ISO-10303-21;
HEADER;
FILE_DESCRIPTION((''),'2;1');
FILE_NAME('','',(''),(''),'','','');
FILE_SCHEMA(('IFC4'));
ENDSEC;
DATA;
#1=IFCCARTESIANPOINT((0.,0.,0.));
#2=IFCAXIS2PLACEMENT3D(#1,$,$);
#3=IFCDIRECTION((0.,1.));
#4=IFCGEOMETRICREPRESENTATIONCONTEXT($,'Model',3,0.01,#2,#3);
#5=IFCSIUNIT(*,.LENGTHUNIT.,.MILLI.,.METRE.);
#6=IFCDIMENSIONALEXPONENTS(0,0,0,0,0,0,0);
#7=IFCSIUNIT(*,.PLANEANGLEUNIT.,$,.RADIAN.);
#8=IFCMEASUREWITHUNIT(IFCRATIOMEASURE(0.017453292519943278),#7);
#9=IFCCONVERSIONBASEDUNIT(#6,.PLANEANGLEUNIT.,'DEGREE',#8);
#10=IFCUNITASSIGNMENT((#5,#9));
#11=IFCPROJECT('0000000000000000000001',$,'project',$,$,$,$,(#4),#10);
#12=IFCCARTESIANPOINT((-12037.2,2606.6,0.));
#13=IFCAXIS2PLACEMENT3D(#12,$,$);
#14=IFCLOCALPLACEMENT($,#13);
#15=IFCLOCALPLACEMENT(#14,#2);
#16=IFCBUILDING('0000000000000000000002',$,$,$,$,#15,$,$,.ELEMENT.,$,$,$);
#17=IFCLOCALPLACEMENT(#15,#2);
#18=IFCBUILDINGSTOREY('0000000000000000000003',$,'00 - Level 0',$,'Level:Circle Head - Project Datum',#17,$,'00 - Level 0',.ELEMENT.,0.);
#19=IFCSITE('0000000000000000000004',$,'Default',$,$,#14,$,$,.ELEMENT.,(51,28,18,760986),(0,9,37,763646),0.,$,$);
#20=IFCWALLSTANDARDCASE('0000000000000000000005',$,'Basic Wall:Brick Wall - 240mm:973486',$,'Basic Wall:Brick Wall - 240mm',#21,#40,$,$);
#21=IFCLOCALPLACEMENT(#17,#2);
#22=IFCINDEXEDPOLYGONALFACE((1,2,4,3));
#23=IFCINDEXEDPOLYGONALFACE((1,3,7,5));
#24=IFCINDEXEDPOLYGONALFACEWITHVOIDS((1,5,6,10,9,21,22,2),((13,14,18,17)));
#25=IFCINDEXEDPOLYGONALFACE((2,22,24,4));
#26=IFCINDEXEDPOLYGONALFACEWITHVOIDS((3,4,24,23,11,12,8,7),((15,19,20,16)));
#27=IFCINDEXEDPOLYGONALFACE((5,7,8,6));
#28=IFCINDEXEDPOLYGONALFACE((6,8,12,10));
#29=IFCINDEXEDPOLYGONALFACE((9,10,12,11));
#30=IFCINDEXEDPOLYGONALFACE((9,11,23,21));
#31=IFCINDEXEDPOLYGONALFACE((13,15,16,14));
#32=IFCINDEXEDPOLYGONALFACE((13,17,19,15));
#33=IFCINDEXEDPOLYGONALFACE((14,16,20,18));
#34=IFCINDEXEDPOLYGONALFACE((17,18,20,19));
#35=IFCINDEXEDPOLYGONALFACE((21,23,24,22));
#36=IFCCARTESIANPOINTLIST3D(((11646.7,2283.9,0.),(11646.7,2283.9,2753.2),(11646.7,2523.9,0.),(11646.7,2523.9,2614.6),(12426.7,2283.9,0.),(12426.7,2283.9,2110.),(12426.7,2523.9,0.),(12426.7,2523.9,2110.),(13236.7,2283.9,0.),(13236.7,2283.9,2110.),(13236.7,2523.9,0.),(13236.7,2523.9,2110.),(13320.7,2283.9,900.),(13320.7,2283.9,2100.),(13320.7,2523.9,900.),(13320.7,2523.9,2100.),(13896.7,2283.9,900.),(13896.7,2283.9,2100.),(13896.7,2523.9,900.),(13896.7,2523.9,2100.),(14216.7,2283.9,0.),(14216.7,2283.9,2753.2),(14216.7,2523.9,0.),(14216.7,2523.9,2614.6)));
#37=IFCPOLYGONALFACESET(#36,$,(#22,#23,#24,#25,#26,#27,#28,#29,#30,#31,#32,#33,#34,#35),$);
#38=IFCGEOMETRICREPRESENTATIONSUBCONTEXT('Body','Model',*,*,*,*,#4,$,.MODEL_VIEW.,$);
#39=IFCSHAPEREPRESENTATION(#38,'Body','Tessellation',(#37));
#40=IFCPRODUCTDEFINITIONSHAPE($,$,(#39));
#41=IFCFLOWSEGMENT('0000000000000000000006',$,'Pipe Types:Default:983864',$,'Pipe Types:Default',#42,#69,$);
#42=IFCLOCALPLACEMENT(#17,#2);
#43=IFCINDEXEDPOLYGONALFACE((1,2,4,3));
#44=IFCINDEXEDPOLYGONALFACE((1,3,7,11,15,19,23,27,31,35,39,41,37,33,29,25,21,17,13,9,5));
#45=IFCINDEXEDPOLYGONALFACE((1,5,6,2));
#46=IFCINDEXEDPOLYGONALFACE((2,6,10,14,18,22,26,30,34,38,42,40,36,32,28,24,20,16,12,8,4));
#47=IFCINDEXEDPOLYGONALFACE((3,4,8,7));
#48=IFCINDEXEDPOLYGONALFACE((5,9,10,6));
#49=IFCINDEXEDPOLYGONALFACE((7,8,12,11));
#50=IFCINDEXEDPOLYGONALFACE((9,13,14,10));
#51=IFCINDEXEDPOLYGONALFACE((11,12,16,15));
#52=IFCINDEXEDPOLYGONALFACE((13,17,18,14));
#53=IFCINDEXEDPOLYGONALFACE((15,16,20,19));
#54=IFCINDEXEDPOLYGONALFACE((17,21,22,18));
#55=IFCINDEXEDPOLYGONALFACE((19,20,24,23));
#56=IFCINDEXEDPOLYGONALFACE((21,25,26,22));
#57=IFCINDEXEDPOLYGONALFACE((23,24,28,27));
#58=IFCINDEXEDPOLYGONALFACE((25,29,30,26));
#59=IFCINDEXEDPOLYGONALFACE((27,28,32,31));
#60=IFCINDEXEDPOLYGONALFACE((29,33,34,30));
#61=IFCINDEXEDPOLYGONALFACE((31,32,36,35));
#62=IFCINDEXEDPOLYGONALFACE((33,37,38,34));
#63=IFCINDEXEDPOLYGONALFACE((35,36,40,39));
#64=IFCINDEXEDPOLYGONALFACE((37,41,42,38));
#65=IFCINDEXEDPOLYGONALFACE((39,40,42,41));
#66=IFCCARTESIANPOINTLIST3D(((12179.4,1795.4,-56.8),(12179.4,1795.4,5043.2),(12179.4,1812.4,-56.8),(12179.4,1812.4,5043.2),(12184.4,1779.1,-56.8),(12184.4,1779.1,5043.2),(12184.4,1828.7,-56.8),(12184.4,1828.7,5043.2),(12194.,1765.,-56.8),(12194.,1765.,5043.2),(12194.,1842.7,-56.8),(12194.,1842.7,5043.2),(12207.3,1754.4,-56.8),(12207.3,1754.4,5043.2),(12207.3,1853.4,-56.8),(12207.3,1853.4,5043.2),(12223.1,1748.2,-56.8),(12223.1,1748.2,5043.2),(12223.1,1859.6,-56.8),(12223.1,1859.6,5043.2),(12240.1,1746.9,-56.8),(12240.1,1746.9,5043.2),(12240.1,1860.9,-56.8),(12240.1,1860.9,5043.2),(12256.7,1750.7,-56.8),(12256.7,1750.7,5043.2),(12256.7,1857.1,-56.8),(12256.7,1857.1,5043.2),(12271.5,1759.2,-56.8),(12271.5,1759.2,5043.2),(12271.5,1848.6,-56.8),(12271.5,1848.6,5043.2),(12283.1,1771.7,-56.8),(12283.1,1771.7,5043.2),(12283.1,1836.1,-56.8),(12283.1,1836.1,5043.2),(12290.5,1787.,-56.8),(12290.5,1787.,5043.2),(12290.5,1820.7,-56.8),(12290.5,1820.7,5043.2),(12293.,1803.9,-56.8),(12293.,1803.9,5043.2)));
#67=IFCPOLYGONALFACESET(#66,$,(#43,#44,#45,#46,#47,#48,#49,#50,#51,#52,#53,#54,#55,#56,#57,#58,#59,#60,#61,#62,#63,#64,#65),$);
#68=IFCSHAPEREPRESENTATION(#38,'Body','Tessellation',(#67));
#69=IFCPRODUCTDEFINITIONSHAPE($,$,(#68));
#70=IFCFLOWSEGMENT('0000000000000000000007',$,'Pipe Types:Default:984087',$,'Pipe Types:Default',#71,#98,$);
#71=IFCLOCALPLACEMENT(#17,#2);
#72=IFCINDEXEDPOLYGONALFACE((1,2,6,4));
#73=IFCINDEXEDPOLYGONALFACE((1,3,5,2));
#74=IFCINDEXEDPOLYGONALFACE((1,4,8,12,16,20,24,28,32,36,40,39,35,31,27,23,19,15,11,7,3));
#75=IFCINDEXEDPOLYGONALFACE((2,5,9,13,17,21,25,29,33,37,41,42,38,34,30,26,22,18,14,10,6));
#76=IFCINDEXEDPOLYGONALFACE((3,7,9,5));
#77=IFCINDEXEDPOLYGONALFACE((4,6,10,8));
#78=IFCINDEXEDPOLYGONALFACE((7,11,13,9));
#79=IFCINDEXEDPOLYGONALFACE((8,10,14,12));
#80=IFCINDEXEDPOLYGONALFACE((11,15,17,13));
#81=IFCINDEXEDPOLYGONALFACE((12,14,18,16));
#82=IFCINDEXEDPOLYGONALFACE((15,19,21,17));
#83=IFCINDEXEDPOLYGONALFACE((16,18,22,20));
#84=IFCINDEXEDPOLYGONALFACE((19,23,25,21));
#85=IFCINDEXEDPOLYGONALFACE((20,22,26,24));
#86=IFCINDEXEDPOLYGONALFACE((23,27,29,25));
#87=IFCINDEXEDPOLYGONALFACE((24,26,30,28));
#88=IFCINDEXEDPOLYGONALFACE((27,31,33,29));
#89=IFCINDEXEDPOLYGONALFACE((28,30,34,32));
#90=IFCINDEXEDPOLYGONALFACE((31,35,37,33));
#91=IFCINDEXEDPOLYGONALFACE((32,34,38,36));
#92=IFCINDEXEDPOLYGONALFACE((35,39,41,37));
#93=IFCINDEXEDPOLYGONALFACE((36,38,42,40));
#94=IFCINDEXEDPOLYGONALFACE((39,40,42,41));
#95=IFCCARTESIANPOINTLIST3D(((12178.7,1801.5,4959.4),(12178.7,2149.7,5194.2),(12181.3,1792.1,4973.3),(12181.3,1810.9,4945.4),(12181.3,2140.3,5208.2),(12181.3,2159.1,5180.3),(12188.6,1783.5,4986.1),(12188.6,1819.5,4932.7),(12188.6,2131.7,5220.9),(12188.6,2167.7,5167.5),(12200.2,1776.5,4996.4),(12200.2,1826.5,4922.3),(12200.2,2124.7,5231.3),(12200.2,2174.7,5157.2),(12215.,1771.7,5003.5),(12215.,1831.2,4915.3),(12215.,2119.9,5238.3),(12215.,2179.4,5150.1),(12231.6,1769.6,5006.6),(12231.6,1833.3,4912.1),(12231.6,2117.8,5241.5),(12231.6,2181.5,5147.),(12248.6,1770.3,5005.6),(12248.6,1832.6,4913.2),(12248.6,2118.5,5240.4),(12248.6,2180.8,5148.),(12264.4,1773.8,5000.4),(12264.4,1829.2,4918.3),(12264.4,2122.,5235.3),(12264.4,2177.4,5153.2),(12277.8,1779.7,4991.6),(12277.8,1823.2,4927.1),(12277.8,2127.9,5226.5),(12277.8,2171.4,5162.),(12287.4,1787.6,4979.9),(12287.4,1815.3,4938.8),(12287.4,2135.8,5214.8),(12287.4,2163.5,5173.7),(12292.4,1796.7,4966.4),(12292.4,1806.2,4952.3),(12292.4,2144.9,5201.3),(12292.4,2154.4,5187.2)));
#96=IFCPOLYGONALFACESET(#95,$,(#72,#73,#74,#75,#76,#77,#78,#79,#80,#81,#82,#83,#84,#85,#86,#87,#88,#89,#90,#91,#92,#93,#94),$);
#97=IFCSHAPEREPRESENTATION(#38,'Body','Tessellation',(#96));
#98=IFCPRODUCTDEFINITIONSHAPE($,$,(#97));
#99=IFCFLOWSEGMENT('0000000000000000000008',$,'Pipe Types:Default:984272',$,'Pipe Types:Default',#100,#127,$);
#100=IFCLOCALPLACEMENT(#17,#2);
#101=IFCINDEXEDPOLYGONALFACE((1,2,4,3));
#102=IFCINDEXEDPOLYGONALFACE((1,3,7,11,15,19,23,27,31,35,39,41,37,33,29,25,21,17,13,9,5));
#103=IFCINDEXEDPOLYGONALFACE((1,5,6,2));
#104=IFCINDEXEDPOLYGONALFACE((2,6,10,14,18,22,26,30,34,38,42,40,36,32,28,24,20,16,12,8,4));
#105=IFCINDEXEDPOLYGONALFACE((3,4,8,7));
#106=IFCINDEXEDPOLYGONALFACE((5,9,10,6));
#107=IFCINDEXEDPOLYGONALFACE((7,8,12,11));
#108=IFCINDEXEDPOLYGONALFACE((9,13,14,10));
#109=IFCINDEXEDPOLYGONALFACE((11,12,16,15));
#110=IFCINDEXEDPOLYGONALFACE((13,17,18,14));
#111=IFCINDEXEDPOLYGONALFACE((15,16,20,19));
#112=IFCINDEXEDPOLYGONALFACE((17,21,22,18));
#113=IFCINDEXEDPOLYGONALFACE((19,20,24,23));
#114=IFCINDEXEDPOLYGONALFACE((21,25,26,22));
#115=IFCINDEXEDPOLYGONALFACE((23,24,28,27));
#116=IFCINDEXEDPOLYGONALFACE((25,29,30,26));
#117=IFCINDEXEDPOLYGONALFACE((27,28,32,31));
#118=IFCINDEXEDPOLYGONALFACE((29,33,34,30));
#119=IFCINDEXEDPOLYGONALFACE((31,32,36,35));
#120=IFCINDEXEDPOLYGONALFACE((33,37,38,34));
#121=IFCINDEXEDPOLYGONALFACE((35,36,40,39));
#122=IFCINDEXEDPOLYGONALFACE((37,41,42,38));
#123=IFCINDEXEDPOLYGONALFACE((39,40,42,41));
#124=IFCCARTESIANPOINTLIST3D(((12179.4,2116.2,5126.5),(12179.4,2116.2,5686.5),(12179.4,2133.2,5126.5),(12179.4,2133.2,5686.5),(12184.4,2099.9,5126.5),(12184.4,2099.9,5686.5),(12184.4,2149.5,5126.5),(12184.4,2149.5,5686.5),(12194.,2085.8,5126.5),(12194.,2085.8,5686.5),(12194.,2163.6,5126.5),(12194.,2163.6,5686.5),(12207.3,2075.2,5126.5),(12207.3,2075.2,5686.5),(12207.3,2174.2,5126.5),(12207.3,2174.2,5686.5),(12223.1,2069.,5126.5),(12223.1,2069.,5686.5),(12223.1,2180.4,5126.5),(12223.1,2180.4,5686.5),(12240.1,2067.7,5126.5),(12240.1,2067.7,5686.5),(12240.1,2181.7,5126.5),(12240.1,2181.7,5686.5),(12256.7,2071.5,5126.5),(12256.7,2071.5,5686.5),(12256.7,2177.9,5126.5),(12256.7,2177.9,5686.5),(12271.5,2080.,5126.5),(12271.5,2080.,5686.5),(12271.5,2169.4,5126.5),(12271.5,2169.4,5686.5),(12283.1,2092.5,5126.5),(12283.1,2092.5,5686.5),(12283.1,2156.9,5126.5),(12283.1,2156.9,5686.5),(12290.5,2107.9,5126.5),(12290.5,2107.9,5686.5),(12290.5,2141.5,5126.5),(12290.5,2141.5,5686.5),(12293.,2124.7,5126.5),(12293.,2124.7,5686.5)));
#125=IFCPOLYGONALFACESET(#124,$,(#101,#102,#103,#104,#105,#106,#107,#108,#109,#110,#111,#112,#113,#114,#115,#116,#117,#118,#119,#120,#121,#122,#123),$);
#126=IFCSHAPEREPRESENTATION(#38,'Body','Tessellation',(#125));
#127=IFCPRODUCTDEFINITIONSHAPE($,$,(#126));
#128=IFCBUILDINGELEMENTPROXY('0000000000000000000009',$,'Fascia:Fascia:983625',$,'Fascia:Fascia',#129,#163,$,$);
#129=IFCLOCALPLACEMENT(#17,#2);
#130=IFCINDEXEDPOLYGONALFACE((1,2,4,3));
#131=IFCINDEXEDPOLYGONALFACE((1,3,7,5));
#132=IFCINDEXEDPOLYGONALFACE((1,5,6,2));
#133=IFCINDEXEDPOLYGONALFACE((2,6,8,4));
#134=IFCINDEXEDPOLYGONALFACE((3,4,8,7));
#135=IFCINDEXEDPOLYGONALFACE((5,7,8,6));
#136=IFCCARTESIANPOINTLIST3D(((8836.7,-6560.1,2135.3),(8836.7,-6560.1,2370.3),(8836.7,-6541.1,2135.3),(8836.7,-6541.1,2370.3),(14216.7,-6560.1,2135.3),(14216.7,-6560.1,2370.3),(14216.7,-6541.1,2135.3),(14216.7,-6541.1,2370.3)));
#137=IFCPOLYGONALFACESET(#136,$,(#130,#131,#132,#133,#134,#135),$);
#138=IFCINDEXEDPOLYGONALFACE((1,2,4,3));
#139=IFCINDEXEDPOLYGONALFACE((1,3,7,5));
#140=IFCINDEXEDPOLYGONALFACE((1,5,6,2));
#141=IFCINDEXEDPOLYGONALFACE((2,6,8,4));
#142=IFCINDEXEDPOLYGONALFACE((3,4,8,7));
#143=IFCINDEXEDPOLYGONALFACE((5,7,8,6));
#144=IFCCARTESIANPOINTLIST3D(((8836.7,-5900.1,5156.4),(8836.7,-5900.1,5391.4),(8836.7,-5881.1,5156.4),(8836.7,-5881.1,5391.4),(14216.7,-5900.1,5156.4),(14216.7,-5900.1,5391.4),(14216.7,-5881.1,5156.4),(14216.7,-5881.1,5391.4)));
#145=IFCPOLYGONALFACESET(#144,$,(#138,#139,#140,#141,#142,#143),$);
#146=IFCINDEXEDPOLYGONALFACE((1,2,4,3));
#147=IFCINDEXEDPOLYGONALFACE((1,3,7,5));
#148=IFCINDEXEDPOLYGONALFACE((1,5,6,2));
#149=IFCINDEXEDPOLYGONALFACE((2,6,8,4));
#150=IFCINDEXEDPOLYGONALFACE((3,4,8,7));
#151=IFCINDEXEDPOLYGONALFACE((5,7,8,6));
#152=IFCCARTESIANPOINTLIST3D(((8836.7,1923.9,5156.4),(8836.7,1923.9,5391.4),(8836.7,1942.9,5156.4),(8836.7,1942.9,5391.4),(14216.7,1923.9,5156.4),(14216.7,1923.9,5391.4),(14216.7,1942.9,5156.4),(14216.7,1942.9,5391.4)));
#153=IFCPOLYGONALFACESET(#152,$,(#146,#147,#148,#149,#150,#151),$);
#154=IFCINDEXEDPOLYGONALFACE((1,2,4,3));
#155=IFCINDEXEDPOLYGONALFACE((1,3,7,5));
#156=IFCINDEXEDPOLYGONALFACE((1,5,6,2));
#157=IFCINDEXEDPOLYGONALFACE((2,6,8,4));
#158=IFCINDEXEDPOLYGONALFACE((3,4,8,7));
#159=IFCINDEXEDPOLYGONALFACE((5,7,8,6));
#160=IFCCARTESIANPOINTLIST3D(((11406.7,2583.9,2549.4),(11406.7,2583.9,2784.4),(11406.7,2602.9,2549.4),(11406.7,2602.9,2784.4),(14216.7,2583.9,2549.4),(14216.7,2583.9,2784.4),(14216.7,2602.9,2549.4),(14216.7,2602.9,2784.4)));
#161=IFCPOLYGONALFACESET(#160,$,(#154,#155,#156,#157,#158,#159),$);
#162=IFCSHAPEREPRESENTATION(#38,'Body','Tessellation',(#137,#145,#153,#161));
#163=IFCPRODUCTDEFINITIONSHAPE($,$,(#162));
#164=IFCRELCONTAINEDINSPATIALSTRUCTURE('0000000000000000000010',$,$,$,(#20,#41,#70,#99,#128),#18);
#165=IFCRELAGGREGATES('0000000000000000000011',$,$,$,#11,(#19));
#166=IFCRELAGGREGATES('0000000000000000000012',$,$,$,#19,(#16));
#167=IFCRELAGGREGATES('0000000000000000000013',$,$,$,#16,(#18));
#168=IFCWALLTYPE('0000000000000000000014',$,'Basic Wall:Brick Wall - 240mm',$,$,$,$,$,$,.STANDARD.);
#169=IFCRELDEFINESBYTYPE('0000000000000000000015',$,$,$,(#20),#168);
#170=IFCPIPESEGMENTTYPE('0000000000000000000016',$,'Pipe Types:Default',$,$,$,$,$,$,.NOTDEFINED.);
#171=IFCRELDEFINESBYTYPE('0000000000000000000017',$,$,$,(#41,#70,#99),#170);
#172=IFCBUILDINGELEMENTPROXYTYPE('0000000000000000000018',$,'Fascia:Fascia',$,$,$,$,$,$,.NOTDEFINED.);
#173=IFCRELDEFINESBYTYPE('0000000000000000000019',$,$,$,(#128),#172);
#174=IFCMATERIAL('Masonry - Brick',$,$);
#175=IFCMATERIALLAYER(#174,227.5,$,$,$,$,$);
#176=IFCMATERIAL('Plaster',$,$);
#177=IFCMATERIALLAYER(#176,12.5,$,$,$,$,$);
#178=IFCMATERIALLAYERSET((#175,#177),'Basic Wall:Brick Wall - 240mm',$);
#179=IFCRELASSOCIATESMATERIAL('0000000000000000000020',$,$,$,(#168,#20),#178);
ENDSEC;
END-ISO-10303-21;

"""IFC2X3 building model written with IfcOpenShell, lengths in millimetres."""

from ifc_helpers import new_model, entity, si_unit, converted_unit, direction, frame, frame_2d, origin, origin_2d_with_axis, place, context, subcontext, project, spatial, polyline, rectangle, circle, extrude, clip, bounded_halfspace, material, layer, layer_set, layer_usage, type_object, element, save


model = new_model("IFC2X3")

# Units and contexts
model_context = context("Model", 3, precision=0.01, world=origin(), true_north=direction((0.0, 1.0)))
body_context = subcontext(model_context, "Body", "Model", "MODEL_VIEW")
ifc_project = project(units=[si_unit("LENGTHUNIT", "METRE", prefix="MILLI"), converted_unit("PLANEANGLEUNIT", "DEGREE", entity("IfcRatioMeasure", 0.017453292519943278), si_unit("PLANEANGLEUNIT", "RADIAN"), dimensions=[0, 0, 0, 0, 0, 0, 0])], contexts=[model_context])

# Site, building, storey
site_placement = place(None, frame((-12037.2, 2606.6, 0.0)))
site = spatial("IfcSite", under=ifc_project, at=site_placement, Name="Default", CompositionType="ELEMENT", RefLatitude=(51, 28, 18, 760986), RefLongitude=(0, 9, 37, 763646), RefElevation=0.0)
building_placement = place(site_placement, origin())
building = spatial("IfcBuilding", under=site, at=building_placement, CompositionType="ELEMENT")
storey_placement = place(building_placement, origin())
storey = spatial("IfcBuildingStorey", under=building, at=storey_placement, Name="00 - Level 0", ObjectType="Level:Circle Head - Project Datum", LongName="00 - Level 0", CompositionType="ELEMENT", Elevation=0.0)

# Shared definitions
ifc_material_1 = material(Name="Masonry - Brick")
ifc_material_2 = material(Name="Plaster")

# Shared definitions
ifc_layer_1 = layer(ifc_material_1, 227.5)
ifc_layer_2 = layer(ifc_material_2, 12.5)
ifc_layer_set_1 = layer_set([ifc_layer_1, ifc_layer_2], Name="Basic Wall:Brick Wall - 240mm")
wall_type_1 = type_object("IfcWallType", Name="Basic Wall:Brick Wall - 240mm", PredefinedType="STANDARD", material=ifc_layer_set_1)

# Wall, openings
ifc_layer_usage_1 = layer_usage(ifc_layer_set_1, "AXIS2", "NEGATIVE", 120.0)
wall_1_placement = place(storey_placement, frame((11646.7, 2403.9, 0.0)))
wall_1 = element("IfcWallStandardCase", 1, at=wall_1_placement, inside=storey, type_object=wall_type_1, material=ifc_layer_usage_1, Name="Basic Wall:Brick Wall - 240mm:973486", ObjectType="Basic Wall:Brick Wall - 240mm", context=body_context, shape_type="Clipping", body=[
    clip(extrude(rectangle(XDim=2570.0, YDim=240.0, at=frame_2d((1285.0, 0.0), x_axis=(1.0, 0.0))), origin(), (0.0, 0.0, 1.0), 2753.2), bounded_halfspace(frame((0.0, -120.0, 2753.2), z_axis=(0.0, 0.5, 0.866025), x_axis=(-1.0, 0.0, 0.0)), False, frame((0.0, -120.0, 2753.2)), polyline([(0.0, 0.0), (710184.0, 0.0), (783336.0, 0.0), (783336.0, 73152.0), (0.0, 73152.0), (0.0, 0.0)]))),
])
opening_1_placement = place(wall_1_placement, frame((780.0, -120.0, 0.0)))
element("IfcOpeningElement", 2, at=opening_1_placement, cuts=wall_1, ObjectType="Opening", context=body_context, shape_type="SweptSolid", body=[
    extrude(rectangle(XDim=2110.0, YDim=810.0, at=frame_2d((1055.0, 405.0), x_axis=(-1.0, 0.0))), frame((0.0, 0.0, 0.0), z_axis=(0.0, 1.0, 0.0), x_axis=(0.0, 0.0, 1.0)), (0.0, 0.0, 1.0), 240.0),
])
opening_2_placement = place(wall_1_placement, frame((1674.0, -120.0, 900.0)))
element("IfcOpeningElement", 3, at=opening_2_placement, cuts=wall_1, ObjectType="Opening", context=body_context, shape_type="SweptSolid", body=[
    extrude(rectangle(XDim=1200.0, YDim=576.0, at=frame_2d((600.0, 288.0), x_axis=(-1.0, 0.0))), frame((0.0, 0.0, 0.0), z_axis=(0.0, 1.0, 0.0), x_axis=(0.0, 0.0, 1.0)), (0.0, 0.0, 1.0), 240.0),
])

# Flow segments
pipe_segment_type = type_object("IfcPipeSegmentType", Name="Pipe Types:Default", PredefinedType="NOTDEFINED")
flow_segment_1_placement = place(storey_placement, origin())
element("IfcFlowSegment", 4, at=flow_segment_1_placement, inside=storey, type_object=pipe_segment_type, Name="Pipe Types:Default:983864", ObjectType="Pipe Types:Default", context=body_context, shape_type="SweptSolid", body=[
    extrude(circle(Radius=57.2, at=origin_2d_with_axis()), frame((12235.9, 1803.9, -56.8)), (0.0, 0.0, 1.0), 5100.0),
])
flow_segment_2_placement = place(storey_placement, origin())
element("IfcFlowSegment", 5, at=flow_segment_2_placement, inside=storey, type_object=pipe_segment_type, Name="Pipe Types:Default:984087", ObjectType="Pipe Types:Default", context=body_context, shape_type="SweptSolid", body=[
    extrude(circle(Radius=57.2, at=frame_2d((0.0, 0.0), x_axis=(1.0, 0.0))), frame((12235.9, 1801.5, 4959.4), z_axis=(0.0, 0.829038, 0.559193), x_axis=(-1.0, 0.0, 0.0)), (0.0, 0.0, 1.0), 420.0),
])
flow_segment_3_placement = place(storey_placement, origin())
element("IfcFlowSegment", 6, at=flow_segment_3_placement, inside=storey, type_object=pipe_segment_type, Name="Pipe Types:Default:984272", ObjectType="Pipe Types:Default", context=body_context, shape_type="SweptSolid", body=[
    extrude(circle(Radius=57.2, at=origin_2d_with_axis()), frame((12235.9, 2124.7, 5126.5)), (0.0, 0.0, 1.0), 560.0),
])

# Building element proxy
building_element_proxy_type = type_object("IfcBuildingElementProxyType", Name="Fascia:Fascia", PredefinedType="NOTDEFINED")
proxy_placement = place(storey_placement, origin())
element("IfcBuildingElementProxy", 7, at=proxy_placement, inside=storey, type_object=building_element_proxy_type, Name="Fascia:Fascia:983625", ObjectType="Fascia:Fascia", context=body_context, shape_type="SweptSolid", body=[
    extrude(rectangle(XDim=5380.0, YDim=19.0, at=origin_2d_with_axis()), frame((11526.7, -6550.6, 2135.3)), (0.0, 0.0, 1.0), 235.0),
    extrude(rectangle(XDim=5380.0, YDim=19.0, at=frame_2d((0.0, 0.0), x_axis=(1.0, 0.0))), frame((11526.7, -5890.6, 5156.4)), (0.0, 0.0, 1.0), 235.0),
    extrude(rectangle(XDim=5380.0, YDim=19.0, at=frame_2d((0.0, 0.0), x_axis=(1.0, 0.0))), frame((11526.7, 1933.4, 5156.4), z_axis=(0.0, 0.0, 1.0), x_axis=(-1.0, 0.0, 0.0)), (0.0, 0.0, 1.0), 235.0),
    extrude(rectangle(XDim=2810.0, YDim=19.0, at=frame_2d((0.0, 0.0), x_axis=(1.0, 0.0))), frame((12811.7, 2593.4, 2549.4), z_axis=(0.0, 0.0, 1.0), x_axis=(-1.0, 0.0, 0.0)), (0.0, 0.0, 1.0), 235.0),
])

save(model, "model.ifc")
